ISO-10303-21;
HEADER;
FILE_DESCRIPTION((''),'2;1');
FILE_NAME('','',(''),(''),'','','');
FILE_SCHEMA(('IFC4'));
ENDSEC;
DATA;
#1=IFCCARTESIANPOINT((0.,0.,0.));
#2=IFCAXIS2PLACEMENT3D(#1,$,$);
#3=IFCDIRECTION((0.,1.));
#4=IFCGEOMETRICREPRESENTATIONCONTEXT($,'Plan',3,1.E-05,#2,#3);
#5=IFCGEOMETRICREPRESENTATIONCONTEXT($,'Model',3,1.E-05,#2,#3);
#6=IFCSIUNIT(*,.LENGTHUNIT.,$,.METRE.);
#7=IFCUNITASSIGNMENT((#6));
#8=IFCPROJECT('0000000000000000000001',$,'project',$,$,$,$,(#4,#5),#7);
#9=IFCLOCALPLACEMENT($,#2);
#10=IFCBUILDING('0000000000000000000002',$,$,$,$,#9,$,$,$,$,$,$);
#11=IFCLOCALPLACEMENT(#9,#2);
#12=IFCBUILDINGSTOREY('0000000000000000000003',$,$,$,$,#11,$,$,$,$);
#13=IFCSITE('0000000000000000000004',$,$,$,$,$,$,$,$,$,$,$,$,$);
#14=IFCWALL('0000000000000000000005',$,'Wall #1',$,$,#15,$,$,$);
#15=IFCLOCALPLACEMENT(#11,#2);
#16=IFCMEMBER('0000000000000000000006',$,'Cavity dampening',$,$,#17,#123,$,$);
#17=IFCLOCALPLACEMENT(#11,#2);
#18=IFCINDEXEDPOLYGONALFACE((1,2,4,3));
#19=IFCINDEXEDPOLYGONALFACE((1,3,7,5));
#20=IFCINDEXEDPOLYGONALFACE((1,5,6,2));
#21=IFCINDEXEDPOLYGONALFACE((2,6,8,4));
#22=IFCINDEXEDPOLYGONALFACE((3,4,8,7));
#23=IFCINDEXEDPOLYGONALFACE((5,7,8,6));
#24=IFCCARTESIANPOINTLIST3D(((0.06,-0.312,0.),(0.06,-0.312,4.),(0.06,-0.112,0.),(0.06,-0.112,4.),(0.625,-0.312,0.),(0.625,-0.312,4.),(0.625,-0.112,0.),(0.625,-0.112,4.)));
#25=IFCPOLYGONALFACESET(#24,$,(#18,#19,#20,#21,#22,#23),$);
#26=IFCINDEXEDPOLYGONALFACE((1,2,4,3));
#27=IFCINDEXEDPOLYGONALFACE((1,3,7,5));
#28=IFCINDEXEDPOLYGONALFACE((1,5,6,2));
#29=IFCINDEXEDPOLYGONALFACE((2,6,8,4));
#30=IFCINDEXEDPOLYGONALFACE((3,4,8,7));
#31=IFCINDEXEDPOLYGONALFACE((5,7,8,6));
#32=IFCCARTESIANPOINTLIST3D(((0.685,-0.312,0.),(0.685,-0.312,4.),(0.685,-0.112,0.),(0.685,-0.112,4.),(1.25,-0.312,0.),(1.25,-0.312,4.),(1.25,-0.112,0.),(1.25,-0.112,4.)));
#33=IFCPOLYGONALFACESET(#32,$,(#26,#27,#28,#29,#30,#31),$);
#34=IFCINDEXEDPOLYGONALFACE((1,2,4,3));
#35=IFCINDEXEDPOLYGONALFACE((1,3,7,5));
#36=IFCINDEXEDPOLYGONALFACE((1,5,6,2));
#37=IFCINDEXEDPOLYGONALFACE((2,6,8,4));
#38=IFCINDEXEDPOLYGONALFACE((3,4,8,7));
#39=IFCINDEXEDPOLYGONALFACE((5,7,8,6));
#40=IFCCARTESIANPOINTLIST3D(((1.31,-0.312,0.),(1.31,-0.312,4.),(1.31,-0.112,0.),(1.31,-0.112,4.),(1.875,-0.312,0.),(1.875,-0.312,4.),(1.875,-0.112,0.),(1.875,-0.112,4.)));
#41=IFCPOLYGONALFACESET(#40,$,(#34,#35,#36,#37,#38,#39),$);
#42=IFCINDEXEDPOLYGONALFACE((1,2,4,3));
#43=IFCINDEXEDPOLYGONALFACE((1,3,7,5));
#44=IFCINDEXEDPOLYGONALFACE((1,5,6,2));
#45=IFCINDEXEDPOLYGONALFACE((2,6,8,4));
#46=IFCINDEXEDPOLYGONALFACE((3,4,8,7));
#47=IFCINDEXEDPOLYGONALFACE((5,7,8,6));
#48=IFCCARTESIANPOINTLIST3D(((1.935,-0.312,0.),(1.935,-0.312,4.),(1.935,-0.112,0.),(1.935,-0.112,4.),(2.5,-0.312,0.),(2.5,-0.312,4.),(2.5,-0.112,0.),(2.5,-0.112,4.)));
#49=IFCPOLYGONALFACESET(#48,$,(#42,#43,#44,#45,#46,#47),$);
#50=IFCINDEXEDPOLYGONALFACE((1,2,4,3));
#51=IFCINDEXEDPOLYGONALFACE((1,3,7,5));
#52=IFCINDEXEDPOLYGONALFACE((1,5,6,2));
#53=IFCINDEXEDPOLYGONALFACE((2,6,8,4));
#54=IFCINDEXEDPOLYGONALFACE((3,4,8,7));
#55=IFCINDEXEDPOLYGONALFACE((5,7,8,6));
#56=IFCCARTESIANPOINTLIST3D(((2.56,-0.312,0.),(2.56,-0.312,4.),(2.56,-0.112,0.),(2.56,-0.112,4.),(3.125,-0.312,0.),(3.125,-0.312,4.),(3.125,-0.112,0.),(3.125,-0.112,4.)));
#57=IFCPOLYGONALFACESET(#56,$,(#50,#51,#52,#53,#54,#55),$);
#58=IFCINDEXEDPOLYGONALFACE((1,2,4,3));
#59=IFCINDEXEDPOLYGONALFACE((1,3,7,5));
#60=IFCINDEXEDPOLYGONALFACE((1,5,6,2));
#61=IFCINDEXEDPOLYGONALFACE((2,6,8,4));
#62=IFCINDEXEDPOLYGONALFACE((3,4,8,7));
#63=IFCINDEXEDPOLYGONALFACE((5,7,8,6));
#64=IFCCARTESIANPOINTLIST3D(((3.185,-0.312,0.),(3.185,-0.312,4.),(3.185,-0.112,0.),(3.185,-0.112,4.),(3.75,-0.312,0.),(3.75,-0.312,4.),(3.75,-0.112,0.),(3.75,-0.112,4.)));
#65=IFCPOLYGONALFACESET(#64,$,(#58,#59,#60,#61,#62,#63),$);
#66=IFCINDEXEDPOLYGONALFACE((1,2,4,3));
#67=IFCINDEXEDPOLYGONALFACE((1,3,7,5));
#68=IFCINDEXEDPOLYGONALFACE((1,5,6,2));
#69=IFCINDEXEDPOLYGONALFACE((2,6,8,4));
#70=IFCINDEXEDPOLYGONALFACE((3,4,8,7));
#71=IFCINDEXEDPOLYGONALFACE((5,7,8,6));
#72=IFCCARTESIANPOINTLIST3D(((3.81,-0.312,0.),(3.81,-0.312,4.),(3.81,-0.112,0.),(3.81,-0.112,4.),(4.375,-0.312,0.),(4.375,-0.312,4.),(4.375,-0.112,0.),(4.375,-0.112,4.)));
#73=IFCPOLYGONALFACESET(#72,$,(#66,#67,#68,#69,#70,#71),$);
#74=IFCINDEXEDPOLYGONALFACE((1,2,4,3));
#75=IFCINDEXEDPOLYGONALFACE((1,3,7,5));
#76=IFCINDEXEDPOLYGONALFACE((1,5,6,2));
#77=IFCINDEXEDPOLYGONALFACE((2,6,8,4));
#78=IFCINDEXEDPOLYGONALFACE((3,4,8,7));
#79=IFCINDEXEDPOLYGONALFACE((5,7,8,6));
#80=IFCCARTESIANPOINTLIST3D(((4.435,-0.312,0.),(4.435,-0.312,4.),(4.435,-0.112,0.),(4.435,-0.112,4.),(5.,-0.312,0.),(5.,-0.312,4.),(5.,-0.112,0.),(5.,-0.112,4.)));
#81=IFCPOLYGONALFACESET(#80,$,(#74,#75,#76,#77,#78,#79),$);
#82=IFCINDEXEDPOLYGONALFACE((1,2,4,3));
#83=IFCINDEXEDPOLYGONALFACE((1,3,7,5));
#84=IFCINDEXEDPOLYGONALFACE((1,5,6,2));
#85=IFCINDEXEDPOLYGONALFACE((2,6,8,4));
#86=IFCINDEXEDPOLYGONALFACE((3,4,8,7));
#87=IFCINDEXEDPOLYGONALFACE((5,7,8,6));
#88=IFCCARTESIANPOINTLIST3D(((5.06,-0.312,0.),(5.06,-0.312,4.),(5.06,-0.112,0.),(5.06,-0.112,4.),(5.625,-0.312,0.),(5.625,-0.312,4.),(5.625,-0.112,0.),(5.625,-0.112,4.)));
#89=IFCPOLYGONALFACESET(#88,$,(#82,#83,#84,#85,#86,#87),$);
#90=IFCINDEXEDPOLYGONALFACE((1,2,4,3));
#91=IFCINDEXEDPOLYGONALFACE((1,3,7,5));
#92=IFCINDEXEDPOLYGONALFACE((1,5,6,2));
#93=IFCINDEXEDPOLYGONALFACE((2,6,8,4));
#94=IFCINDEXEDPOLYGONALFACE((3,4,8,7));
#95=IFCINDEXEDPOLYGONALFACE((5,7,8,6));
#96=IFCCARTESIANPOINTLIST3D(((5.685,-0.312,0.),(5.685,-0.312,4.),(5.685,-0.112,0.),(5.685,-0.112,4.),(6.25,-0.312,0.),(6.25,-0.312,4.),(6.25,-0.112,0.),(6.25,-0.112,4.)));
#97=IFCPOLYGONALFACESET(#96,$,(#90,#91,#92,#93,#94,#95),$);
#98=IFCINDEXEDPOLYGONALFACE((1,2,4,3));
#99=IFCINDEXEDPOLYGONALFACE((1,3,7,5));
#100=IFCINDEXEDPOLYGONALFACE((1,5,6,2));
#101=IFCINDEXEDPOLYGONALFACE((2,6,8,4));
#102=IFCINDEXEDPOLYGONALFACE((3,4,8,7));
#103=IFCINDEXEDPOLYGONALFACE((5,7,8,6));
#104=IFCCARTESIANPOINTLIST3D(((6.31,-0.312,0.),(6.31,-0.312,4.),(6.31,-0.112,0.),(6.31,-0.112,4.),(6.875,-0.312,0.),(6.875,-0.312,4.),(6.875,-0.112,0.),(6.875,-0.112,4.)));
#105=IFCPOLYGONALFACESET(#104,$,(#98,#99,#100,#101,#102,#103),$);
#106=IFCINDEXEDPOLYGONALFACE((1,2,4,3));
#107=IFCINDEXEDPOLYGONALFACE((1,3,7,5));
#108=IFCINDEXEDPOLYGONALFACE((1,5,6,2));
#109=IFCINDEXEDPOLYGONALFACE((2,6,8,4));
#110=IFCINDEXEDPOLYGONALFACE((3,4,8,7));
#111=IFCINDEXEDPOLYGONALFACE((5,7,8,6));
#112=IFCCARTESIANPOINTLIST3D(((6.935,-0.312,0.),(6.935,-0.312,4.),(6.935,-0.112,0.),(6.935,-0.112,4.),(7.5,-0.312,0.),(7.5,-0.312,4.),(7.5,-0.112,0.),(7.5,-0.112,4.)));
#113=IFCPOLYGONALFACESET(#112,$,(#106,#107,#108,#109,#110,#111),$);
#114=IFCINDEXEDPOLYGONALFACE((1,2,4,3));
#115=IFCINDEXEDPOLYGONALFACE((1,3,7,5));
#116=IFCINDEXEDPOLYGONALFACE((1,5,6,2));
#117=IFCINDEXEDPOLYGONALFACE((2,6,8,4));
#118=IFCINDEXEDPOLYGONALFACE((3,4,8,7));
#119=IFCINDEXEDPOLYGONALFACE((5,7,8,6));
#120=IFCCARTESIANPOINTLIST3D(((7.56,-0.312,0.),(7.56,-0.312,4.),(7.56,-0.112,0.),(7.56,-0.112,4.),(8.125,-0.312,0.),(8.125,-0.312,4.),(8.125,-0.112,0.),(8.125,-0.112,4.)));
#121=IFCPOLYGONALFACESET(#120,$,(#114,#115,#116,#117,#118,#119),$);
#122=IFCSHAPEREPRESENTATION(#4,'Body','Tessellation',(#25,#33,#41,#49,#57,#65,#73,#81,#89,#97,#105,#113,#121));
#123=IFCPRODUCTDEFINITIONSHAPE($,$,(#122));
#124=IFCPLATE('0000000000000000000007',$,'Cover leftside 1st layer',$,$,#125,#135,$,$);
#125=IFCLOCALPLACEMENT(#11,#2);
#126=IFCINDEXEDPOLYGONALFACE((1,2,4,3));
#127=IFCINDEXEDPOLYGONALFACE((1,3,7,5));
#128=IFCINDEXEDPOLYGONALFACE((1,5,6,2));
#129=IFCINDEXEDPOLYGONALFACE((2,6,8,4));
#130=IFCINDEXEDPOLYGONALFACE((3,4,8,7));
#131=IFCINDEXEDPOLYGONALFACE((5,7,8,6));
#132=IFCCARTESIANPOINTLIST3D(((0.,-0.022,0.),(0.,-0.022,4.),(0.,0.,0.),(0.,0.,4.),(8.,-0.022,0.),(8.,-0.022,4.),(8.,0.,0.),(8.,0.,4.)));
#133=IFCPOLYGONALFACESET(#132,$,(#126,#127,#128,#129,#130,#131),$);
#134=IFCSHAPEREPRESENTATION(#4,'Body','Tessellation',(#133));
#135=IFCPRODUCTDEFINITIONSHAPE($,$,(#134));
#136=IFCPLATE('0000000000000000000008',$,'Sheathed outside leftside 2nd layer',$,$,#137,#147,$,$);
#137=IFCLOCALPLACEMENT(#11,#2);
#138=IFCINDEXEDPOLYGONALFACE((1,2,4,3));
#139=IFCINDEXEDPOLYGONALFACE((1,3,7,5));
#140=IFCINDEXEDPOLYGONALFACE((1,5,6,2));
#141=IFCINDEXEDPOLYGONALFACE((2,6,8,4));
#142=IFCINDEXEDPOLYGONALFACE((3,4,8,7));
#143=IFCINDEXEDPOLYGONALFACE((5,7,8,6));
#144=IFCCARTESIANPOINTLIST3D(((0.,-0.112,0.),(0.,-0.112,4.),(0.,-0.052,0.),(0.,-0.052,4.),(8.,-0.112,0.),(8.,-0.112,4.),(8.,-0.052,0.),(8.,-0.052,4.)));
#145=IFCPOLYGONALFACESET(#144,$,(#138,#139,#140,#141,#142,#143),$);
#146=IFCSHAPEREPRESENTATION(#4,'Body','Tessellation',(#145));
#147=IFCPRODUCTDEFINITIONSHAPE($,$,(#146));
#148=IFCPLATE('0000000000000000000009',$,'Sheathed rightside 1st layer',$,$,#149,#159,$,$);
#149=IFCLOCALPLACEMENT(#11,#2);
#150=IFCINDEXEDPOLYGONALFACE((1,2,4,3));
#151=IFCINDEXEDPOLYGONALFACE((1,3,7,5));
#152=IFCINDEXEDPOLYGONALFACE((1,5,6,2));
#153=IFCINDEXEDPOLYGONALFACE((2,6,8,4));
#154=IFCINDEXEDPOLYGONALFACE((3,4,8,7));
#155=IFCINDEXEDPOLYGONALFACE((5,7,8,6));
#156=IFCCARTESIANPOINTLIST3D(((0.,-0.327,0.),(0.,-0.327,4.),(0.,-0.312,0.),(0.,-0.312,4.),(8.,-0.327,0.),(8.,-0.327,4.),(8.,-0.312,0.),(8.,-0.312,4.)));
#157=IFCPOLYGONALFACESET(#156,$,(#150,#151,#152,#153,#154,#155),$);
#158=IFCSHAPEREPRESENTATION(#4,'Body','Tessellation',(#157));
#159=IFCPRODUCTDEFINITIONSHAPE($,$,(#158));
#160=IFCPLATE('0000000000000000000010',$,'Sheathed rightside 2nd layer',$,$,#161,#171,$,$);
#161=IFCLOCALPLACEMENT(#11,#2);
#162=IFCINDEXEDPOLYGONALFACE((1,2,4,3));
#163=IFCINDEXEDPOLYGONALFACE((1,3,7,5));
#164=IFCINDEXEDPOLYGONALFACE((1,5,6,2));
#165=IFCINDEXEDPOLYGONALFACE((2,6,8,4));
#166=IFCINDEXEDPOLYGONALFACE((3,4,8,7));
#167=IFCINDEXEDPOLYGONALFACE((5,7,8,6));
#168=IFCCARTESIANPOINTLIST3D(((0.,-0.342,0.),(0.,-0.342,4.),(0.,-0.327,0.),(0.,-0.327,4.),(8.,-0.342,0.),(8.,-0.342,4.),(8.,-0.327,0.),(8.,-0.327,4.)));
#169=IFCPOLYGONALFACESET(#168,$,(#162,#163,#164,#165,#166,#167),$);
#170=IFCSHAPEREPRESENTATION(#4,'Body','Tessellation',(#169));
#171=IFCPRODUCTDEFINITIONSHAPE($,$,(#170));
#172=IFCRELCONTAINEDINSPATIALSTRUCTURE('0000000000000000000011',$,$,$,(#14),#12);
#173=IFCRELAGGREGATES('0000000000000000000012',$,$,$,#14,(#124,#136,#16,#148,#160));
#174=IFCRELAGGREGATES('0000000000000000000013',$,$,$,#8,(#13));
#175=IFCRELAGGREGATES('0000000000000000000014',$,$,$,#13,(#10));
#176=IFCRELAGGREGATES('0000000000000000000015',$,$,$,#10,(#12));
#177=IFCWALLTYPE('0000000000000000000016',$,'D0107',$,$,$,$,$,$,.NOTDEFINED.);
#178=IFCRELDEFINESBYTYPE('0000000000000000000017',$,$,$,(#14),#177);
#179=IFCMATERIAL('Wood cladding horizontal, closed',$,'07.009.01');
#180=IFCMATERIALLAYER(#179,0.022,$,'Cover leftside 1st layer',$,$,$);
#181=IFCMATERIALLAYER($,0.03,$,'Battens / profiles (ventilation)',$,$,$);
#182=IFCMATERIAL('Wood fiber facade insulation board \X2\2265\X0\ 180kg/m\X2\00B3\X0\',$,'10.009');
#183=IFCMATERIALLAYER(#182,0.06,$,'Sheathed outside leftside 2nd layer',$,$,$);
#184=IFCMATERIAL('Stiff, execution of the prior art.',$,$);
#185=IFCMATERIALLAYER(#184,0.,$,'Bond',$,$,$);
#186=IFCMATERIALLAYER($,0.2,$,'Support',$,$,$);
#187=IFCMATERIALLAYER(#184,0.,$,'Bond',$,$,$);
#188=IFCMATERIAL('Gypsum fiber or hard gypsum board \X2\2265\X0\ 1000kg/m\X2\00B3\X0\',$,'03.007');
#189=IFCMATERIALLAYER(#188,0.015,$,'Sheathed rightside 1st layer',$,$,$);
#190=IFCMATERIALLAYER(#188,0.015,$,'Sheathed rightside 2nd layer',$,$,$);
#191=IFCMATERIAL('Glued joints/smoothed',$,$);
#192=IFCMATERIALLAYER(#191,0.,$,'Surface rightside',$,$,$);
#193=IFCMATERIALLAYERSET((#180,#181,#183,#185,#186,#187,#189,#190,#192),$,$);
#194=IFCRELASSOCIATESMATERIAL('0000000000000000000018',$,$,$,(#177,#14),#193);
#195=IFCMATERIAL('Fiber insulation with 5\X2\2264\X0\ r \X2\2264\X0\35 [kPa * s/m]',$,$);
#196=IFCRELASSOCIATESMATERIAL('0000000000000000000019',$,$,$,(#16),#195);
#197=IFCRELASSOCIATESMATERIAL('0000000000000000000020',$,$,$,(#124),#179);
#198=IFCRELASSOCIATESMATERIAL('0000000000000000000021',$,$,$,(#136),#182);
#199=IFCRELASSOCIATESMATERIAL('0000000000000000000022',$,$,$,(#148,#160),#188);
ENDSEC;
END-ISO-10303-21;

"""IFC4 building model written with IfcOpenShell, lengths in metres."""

from ifc_helpers import new_model, si_unit, direction, frame, frame_2d, origin, origin_with_axes, place, context, project, spatial, rectangle, extrude, material, layer, layer_set, type_object, element, aggregate, save


model = new_model("IFC4")

# Units and contexts
plan_context = context("Plan", 3, precision=1e-05, world=origin(), true_north=direction((0.0, 1.0)))
model_context = context("Model", 3, precision=1e-05, world=origin(), true_north=direction((0.0, 1.0)))
ifc_project = project(units=[si_unit("LENGTHUNIT", "METRE")], contexts=[plan_context, model_context])

# Site, building, storey
site = spatial("IfcSite", under=ifc_project)
building_placement = place(None, origin())
building = spatial("IfcBuilding", under=site, at=building_placement)
storey_placement = place(building_placement, origin())
storey = spatial("IfcBuildingStorey", under=building, at=storey_placement)

# Wall, member, plates
ifc_material_1 = material(Name="Wood cladding horizontal, closed", Category="07.009.01")
ifc_layer_1 = layer(ifc_material_1, 0.022, Name="Cover leftside 1st layer")
ifc_layer_2 = layer(None, 0.03, Name="Battens / profiles (ventilation)")
ifc_material_2 = material(Name="Wood fiber facade insulation board ≥ 180kg/m³", Category="10.009")
ifc_layer_3 = layer(ifc_material_2, 0.06, Name="Sheathed outside leftside 2nd layer")
ifc_material_3 = material(Name="Stiff, execution of the prior art.")
ifc_layer_4 = layer(ifc_material_3, 0.0, Name="Bond")
ifc_layer_5 = layer(None, 0.2, Name="Support")
ifc_layer_6 = layer(ifc_material_3, 0.0, Name="Bond")
ifc_material_4 = material(Name="Gypsum fiber or hard gypsum board ≥ 1000kg/m³", Category="03.007")
ifc_layer_7 = layer(ifc_material_4, 0.015, Name="Sheathed rightside 1st layer")
ifc_layer_8 = layer(ifc_material_4, 0.015, Name="Sheathed rightside 2nd layer")
ifc_material_5 = material(Name="Glued joints/smoothed")
ifc_layer_9 = layer(ifc_material_5, 0.0, Name="Surface rightside")
ifc_layer_set = layer_set([ifc_layer_1, ifc_layer_2, ifc_layer_3, ifc_layer_4, ifc_layer_5, ifc_layer_6, ifc_layer_7, ifc_layer_8, ifc_layer_9])
wall_type = type_object("IfcWallType", Name="D0107", PredefinedType="NOTDEFINED", material=ifc_layer_set)
wall_placement = place(None, frame((0.0, 0.0, 0.0), z_axis=(0.0, -1.0, 0.0), x_axis=(1.0, 0.0, 0.0)))
wall = element("IfcWall", 1, at=wall_placement, inside=storey, type_object=wall_type, material=ifc_layer_set, Name="Wall #1")
ifc_material_6 = material(Name="Fiber insulation with 5≤ r ≤35 [kPa * s/m]")
member_1_placement = place(wall_placement, origin())
member_1 = element("IfcMember", 2, at=member_1_placement, material=ifc_material_6, Name="Cavity dampening", context=plan_context, shape_type="SweptSolid", body=[
    extrude(rectangle(XDim=0.565, YDim=0.2, at=frame_2d((0.2825, 0.1), x_axis=(1.0, 0.0))), frame((0.06, 4.0, 0.112), z_axis=(0.0, -1.0, 0.0), x_axis=(1.0, 0.0, 0.0)), (0.0, 0.0, 1.0), 4.0),
    extrude(rectangle(XDim=0.565, YDim=0.2, at=frame_2d((0.2825, 0.1), x_axis=(1.0, 0.0))), frame((0.685, 4.0, 0.112), z_axis=(0.0, -1.0, 0.0), x_axis=(1.0, 0.0, 0.0)), (0.0, 0.0, 1.0), 4.0),
    extrude(rectangle(XDim=0.565, YDim=0.2, at=frame_2d((0.2825, 0.1), x_axis=(1.0, 0.0))), frame((1.31, 4.0, 0.112), z_axis=(0.0, -1.0, 0.0), x_axis=(1.0, 0.0, 0.0)), (0.0, 0.0, 1.0), 4.0),
    extrude(rectangle(XDim=0.565, YDim=0.2, at=frame_2d((0.2825, 0.1), x_axis=(1.0, 0.0))), frame((1.935, 4.0, 0.112), z_axis=(0.0, -1.0, 0.0), x_axis=(1.0, 0.0, 0.0)), (0.0, 0.0, 1.0), 4.0),
    extrude(rectangle(XDim=0.565, YDim=0.2, at=frame_2d((0.2825, 0.1), x_axis=(1.0, 0.0))), frame((2.56, 4.0, 0.112), z_axis=(0.0, -1.0, 0.0), x_axis=(1.0, 0.0, 0.0)), (0.0, 0.0, 1.0), 4.0),
    extrude(rectangle(XDim=0.565, YDim=0.2, at=frame_2d((0.2825, 0.1), x_axis=(1.0, 0.0))), frame((3.185, 4.0, 0.112), z_axis=(0.0, -1.0, 0.0), x_axis=(1.0, 0.0, 0.0)), (0.0, 0.0, 1.0), 4.0),
    extrude(rectangle(XDim=0.565, YDim=0.2, at=frame_2d((0.2825, 0.1), x_axis=(1.0, 0.0))), frame((3.81, 4.0, 0.112), z_axis=(0.0, -1.0, 0.0), x_axis=(1.0, 0.0, 0.0)), (0.0, 0.0, 1.0), 4.0),
    extrude(rectangle(XDim=0.565, YDim=0.2, at=frame_2d((0.2825, 0.1), x_axis=(1.0, 0.0))), frame((4.435, 4.0, 0.112), z_axis=(0.0, -1.0, 0.0), x_axis=(1.0, 0.0, 0.0)), (0.0, 0.0, 1.0), 4.0),
    extrude(rectangle(XDim=0.565, YDim=0.2, at=frame_2d((0.2825, 0.1), x_axis=(1.0, 0.0))), frame((5.06, 4.0, 0.112), z_axis=(0.0, -1.0, 0.0), x_axis=(1.0, 0.0, 0.0)), (0.0, 0.0, 1.0), 4.0),
    extrude(rectangle(XDim=0.565, YDim=0.2, at=frame_2d((0.2825, 0.1), x_axis=(1.0, 0.0))), frame((5.685, 4.0, 0.112), z_axis=(0.0, -1.0, 0.0), x_axis=(1.0, 0.0, 0.0)), (0.0, 0.0, 1.0), 4.0),
    extrude(rectangle(XDim=0.565, YDim=0.2, at=frame_2d((0.2825, 0.1), x_axis=(1.0, 0.0))), frame((6.31, 4.0, 0.112), z_axis=(0.0, -1.0, 0.0), x_axis=(1.0, 0.0, 0.0)), (0.0, 0.0, 1.0), 4.0),
    extrude(rectangle(XDim=0.565, YDim=0.2, at=frame_2d((0.2825, 0.1), x_axis=(1.0, 0.0))), frame((6.935, 4.0, 0.112), z_axis=(0.0, -1.0, 0.0), x_axis=(1.0, 0.0, 0.0)), (0.0, 0.0, 1.0), 4.0),
    extrude(rectangle(XDim=0.565, YDim=0.2, at=frame_2d((0.2825, 0.1), x_axis=(1.0, 0.0))), frame((7.56, 4.0, 0.112), z_axis=(0.0, -1.0, 0.0), x_axis=(1.0, 0.0, 0.0)), (0.0, 0.0, 1.0), 4.0),
])
plate_1_placement = place(wall_placement, origin())
plate_1 = element("IfcPlate", 3, at=plate_1_placement, material=ifc_material_1, Name="Cover leftside 1st layer", context=plan_context, shape_type="SweptSolid", body=[
    extrude(rectangle(XDim=8.0, YDim=4.0, at=frame_2d((4.0, 2.0), x_axis=(1.0, 0.0))), origin_with_axes(), (0.0, 0.0, 1.0), 0.022),
])
plate_2_placement = place(wall_placement, origin())
plate_2 = element("IfcPlate", 4, at=plate_2_placement, material=ifc_material_2, Name="Sheathed outside leftside 2nd layer", context=plan_context, shape_type="SweptSolid", body=[
    extrude(rectangle(XDim=8.0, YDim=4.0, at=frame_2d((4.0, 2.0), x_axis=(1.0, 0.0))), frame((0.0, 0.0, 0.052), z_axis=(0.0, 0.0, 1.0), x_axis=(1.0, 0.0, 0.0)), (0.0, 0.0, 1.0), 0.06),
])
plate_3_placement = place(wall_placement, origin())
plate_3 = element("IfcPlate", 5, at=plate_3_placement, material=ifc_material_4, Name="Sheathed rightside 1st layer", context=plan_context, shape_type="SweptSolid", body=[
    extrude(rectangle(XDim=8.0, YDim=4.0, at=frame_2d((4.0, 2.0), x_axis=(1.0, 0.0))), frame((0.0, 0.0, 0.312), z_axis=(0.0, 0.0, 1.0), x_axis=(1.0, 0.0, 0.0)), (0.0, 0.0, 1.0), 0.015),
])
plate_4_placement = place(wall_placement, origin())
plate_4 = element("IfcPlate", 6, at=plate_4_placement, material=ifc_material_4, Name="Sheathed rightside 2nd layer", context=plan_context, shape_type="SweptSolid", body=[
    extrude(rectangle(XDim=8.0, YDim=4.0, at=frame_2d((4.0, 2.0), x_axis=(1.0, 0.0))), frame((0.0, 0.0, 0.327), z_axis=(0.0, 0.0, 1.0), x_axis=(1.0, 0.0, 0.0)), (0.0, 0.0, 1.0), 0.015),
])
aggregate(wall, [plate_1, plate_2, member_1, plate_3, plate_4])

save(model, "model.ifc")
